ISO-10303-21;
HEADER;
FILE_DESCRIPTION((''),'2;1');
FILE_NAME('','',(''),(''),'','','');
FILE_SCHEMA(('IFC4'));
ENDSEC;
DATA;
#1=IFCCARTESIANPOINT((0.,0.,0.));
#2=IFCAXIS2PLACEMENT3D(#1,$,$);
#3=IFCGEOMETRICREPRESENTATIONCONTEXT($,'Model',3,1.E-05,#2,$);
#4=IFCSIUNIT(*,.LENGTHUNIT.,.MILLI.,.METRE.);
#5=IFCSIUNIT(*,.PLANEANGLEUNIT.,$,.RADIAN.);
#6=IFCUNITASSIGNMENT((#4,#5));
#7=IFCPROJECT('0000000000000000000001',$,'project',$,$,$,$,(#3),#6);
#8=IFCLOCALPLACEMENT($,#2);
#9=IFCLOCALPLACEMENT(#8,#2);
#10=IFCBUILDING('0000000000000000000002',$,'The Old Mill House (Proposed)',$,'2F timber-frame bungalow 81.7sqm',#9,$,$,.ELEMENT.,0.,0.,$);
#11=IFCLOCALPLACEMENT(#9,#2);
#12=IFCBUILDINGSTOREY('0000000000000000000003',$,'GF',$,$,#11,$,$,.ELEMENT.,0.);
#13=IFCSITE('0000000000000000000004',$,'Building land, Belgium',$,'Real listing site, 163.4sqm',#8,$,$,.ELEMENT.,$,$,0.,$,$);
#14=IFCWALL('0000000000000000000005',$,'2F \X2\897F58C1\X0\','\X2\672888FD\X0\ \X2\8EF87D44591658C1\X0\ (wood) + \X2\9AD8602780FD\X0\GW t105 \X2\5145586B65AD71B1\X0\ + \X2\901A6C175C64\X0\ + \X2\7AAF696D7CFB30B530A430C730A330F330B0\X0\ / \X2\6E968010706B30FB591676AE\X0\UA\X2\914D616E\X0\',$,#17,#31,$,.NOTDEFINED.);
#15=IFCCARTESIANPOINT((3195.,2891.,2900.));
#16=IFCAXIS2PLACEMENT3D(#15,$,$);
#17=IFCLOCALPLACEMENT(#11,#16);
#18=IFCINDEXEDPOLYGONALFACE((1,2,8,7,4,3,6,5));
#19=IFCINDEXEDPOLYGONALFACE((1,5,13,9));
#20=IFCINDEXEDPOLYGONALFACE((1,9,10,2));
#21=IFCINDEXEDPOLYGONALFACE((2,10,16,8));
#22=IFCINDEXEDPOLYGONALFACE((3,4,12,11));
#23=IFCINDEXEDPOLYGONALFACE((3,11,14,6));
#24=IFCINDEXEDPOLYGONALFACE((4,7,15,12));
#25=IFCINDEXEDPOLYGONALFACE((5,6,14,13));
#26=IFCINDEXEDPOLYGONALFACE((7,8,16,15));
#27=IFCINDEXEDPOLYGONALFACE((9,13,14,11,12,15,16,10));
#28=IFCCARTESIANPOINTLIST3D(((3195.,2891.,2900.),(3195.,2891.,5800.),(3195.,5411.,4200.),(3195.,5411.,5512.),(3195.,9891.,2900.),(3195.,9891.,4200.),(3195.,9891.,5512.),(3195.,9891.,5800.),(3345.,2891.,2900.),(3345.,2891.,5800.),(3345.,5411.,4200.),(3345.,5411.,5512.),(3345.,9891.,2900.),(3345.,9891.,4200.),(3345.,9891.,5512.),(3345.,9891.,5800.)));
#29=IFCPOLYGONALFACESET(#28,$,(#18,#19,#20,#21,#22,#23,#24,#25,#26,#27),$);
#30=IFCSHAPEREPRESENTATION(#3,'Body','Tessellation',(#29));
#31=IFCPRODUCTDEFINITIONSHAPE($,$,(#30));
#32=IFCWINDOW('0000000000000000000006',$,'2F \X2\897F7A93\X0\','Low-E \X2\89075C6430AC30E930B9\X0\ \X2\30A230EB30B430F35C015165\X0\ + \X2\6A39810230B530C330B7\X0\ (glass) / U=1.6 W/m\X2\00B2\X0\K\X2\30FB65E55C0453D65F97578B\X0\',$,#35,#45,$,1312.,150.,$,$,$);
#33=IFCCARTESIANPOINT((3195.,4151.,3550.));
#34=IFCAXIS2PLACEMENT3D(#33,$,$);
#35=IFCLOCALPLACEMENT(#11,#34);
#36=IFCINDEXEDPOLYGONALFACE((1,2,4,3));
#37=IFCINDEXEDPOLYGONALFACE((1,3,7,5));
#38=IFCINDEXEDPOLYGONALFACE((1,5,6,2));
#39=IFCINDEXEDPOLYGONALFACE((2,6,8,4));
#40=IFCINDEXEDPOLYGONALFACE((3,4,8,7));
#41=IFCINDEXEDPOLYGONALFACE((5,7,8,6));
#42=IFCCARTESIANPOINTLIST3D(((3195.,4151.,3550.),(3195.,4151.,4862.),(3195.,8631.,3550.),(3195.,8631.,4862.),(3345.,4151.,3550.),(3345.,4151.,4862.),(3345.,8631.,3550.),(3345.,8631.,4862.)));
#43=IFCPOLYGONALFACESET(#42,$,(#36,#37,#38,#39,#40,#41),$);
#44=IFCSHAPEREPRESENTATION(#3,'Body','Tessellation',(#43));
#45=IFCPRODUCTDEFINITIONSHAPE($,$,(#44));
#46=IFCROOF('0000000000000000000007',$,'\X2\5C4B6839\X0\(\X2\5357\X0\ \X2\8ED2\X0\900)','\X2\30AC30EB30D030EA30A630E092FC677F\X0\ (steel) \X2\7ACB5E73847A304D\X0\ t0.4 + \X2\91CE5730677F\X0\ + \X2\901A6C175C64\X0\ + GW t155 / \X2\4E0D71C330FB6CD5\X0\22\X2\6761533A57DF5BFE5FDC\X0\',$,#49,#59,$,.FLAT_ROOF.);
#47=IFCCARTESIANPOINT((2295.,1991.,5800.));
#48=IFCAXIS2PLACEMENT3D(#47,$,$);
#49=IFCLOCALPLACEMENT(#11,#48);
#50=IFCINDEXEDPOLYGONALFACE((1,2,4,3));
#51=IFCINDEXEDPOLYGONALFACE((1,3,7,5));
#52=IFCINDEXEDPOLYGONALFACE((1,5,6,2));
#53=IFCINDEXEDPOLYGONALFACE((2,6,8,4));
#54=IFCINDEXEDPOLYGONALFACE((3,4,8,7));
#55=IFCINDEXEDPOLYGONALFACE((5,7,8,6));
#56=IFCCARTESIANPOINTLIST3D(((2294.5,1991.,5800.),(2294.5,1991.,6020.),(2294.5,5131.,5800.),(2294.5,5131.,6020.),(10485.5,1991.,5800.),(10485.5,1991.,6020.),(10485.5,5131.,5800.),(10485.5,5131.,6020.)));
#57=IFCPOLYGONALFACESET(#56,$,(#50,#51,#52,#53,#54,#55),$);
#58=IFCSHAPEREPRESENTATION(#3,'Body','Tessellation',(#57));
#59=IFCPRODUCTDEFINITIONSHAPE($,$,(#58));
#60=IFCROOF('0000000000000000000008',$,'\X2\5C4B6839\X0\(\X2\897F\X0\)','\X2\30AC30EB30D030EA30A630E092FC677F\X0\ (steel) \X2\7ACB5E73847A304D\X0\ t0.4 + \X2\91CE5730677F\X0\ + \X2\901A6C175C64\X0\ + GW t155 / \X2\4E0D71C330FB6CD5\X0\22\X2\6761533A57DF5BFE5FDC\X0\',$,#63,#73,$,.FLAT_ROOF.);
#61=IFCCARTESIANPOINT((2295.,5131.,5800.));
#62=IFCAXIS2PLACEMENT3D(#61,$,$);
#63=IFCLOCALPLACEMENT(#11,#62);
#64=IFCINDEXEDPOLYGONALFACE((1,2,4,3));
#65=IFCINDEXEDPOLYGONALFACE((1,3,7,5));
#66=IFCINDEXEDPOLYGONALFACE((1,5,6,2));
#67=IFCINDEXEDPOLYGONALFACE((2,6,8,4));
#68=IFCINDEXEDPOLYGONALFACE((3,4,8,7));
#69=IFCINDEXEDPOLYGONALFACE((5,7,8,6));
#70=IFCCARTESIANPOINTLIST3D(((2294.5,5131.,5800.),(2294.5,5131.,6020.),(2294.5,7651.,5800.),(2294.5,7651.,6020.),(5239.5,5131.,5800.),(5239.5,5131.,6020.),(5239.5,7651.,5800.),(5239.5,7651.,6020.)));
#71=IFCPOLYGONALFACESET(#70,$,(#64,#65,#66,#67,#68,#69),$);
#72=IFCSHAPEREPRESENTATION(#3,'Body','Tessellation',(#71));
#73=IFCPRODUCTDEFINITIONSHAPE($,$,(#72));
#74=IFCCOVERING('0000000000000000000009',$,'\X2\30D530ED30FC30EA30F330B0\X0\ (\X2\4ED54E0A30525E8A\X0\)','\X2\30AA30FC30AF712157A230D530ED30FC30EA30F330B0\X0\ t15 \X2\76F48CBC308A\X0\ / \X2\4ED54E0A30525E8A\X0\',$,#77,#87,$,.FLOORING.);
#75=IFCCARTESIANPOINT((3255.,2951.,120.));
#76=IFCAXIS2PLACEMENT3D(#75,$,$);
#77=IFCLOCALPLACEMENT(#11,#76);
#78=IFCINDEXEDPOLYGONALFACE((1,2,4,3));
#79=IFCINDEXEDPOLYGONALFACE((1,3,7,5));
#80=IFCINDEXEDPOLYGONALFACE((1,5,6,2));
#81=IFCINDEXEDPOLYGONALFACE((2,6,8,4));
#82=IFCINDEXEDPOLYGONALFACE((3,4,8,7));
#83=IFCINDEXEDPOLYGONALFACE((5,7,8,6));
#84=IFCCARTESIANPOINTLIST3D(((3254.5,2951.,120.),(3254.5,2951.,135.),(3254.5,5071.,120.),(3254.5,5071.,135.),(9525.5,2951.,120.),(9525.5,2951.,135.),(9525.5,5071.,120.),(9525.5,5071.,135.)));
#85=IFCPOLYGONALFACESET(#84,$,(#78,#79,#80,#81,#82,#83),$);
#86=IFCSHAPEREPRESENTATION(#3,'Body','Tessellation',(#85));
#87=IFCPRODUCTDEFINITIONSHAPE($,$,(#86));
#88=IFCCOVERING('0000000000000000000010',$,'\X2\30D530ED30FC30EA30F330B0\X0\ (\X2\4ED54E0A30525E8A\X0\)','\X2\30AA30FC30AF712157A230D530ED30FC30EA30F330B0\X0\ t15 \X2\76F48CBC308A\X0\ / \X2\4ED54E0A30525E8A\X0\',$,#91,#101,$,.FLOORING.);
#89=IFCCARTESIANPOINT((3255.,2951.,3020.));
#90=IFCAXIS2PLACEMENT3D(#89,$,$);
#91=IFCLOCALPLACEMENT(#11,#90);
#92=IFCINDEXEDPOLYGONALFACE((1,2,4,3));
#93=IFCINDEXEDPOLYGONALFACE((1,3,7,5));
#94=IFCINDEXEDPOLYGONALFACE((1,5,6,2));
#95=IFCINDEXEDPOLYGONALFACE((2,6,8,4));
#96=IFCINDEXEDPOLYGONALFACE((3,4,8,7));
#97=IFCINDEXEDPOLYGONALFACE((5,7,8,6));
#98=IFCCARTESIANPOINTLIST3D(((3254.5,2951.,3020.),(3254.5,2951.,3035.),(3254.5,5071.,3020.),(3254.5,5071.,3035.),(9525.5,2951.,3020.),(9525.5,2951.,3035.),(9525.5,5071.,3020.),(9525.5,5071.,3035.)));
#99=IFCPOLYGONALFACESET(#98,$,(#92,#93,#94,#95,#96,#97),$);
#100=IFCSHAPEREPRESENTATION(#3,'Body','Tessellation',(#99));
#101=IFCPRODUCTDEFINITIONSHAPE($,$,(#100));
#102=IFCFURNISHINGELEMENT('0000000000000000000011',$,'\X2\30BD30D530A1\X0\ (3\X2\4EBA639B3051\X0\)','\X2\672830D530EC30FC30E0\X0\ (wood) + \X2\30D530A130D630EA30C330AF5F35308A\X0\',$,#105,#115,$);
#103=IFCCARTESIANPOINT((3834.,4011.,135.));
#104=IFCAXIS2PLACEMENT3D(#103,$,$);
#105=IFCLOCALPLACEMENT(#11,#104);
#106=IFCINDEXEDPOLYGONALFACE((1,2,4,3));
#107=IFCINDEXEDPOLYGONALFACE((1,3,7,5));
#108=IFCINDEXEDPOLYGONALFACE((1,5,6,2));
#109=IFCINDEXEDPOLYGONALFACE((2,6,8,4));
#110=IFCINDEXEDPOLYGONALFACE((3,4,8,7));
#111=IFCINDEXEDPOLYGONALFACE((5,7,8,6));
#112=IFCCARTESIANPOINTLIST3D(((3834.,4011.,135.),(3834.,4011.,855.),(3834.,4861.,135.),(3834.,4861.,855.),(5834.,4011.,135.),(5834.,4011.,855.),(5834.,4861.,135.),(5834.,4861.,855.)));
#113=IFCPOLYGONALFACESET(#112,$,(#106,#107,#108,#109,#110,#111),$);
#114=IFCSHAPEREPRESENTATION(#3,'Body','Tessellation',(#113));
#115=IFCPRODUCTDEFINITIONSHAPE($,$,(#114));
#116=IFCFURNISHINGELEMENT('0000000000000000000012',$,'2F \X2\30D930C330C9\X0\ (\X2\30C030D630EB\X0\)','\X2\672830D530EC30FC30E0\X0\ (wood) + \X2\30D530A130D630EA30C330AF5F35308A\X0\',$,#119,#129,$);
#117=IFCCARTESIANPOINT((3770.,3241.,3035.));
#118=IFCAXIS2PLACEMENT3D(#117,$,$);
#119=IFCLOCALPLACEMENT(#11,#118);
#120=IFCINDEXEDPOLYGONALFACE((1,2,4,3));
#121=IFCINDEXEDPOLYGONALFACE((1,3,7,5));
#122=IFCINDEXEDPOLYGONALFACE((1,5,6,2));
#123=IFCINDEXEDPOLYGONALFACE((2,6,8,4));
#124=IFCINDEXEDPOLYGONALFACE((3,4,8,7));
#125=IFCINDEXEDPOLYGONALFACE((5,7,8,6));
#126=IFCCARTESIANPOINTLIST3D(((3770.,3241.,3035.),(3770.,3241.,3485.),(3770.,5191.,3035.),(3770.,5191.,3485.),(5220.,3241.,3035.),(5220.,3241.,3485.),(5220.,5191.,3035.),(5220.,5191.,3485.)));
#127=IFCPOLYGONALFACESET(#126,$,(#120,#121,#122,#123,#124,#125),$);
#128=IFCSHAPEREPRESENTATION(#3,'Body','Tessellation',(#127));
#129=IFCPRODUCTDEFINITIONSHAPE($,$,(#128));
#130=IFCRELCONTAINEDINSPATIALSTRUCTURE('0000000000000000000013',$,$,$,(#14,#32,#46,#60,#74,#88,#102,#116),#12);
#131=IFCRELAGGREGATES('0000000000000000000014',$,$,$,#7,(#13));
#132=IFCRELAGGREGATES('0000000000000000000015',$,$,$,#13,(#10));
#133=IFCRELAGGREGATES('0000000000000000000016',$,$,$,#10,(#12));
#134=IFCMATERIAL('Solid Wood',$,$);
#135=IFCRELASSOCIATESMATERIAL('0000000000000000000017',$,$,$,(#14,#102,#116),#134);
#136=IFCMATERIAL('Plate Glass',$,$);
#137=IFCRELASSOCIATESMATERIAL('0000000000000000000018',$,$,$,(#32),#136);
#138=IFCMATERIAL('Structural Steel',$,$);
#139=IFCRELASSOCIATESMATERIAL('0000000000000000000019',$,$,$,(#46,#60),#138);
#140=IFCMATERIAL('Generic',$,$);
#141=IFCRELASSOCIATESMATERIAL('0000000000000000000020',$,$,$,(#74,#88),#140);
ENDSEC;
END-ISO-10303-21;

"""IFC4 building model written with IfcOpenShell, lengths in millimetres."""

from ifc_helpers import new_model, si_unit, frame, frame_2d, origin, place, context, project, spatial, rectangle, extrude, material, element, fill, save


model = new_model("IFC4")

# Units and contexts
model_context = context("Model", 3, precision=1e-05, world=origin())
ifc_project = project(units=[si_unit("LENGTHUNIT", "METRE", prefix="MILLI"), si_unit("PLANEANGLEUNIT", "RADIAN")], contexts=[model_context])

# Site, building, storey
site_placement = place(None, origin())
site = spatial("IfcSite", under=ifc_project, at=site_placement, Name="Building land, Belgium", ObjectType="Real listing site, 163.4sqm", CompositionType="ELEMENT", RefElevation=0.0)
building_placement = place(site_placement, origin())
building = spatial("IfcBuilding", under=site, at=building_placement, Name="The Old Mill House (Proposed)", ObjectType="2F timber-frame bungalow 81.7sqm", CompositionType="ELEMENT", ElevationOfRefHeight=0.0, ElevationOfTerrain=0.0)
storey_placement = place(building_placement, origin())
storey = spatial("IfcBuildingStorey", under=building, at=storey_placement, Name="GF", CompositionType="ELEMENT", Elevation=0.0)

# Shared definitions
ifc_material_1 = material(Name="Solid Wood")

# Shared definitions
ifc_material_2 = material(Name="Plate Glass")

# Wall, opening, window
wall_1_placement = place(storey_placement, frame((3195.0, 2891.0, 2900.0)))
wall_1 = element("IfcWall", 1, at=wall_1_placement, inside=storey, material=ifc_material_1, Name="2F 西壁", Description="木製 軸組外壁 (wood) + 高性能GW t105 充填断熱 + 通気層 + 窯業系サイディング / 準耐火・外皮UA配慮", PredefinedType="NOTDEFINED", context=model_context, shape_type="SweptSolid", body=[
    extrude(rectangle(XDim=150.0, YDim=7000.0, at=frame_2d((75.0, 3500.0))), frame((3195.0, 2891.0, 2900.0)), (0.0, 0.0, 1.0), 2900.0),
])
opening_1_placement = place(storey_placement, frame((3195.0, 4151.0, 3550.0)))
opening_1 = element("IfcOpeningElement", 2, at=opening_1_placement, cuts=wall_1, PredefinedType="NOTDEFINED", context=model_context, shape_type="SweptSolid", body=[
    extrude(rectangle(XDim=150.0, YDim=4480.0, at=frame_2d((75.0, 2240.0))), frame((3195.0, 4151.0, 3550.0)), (0.0, 0.0, 1.0), 1312.0),
])
window_1_placement = place(storey_placement, frame((3195.0, 4151.0, 3550.0)))
window_1 = element("IfcWindow", 3, at=window_1_placement, inside=storey, material=ifc_material_2, Name="2F 西窓", Description="Low-E 複層ガラス アルゴン封入 + 樹脂サッシ (glass) / U=1.6 W/m²K・日射取得型", OverallHeight=1312.0, OverallWidth=150.0, context=model_context, shape_type="SweptSolid", body=[
    extrude(rectangle(XDim=150.0, YDim=4480.0, at=frame_2d((75.0, 2240.0))), frame((3195.0, 4151.0, 3550.0)), (0.0, 0.0, 1.0), 1312.0),
])
fill(opening_1, window_1)

# Roofs
ifc_material_3 = material(Name="Structural Steel")
roof_1_placement = place(storey_placement, frame((2295.0, 1991.0, 5800.0)))
element("IfcRoof", 4, at=roof_1_placement, inside=storey, material=ifc_material_3, Name="屋根(南 軒900)", Description="ガルバリウム鋼板 (steel) 立平葺き t0.4 + 野地板 + 通気層 + GW t155 / 不燃・法22条区域対応", PredefinedType="FLAT_ROOF", context=model_context, shape_type="SweptSolid", body=[
    extrude(rectangle(XDim=8191.0, YDim=3140.0, at=frame_2d((4095.0, 1570.0))), frame((2295.0, 1991.0, 5800.0)), (0.0, 0.0, 1.0), 220.0),
])
roof_2_placement = place(storey_placement, frame((2295.0, 5131.0, 5800.0)))
element("IfcRoof", 5, at=roof_2_placement, inside=storey, material=ifc_material_3, Name="屋根(西)", Description="ガルバリウム鋼板 (steel) 立平葺き t0.4 + 野地板 + 通気層 + GW t155 / 不燃・法22条区域対応", PredefinedType="FLAT_ROOF", context=model_context, shape_type="SweptSolid", body=[
    extrude(rectangle(XDim=2945.0, YDim=2520.0, at=frame_2d((1472.0, 1260.0))), frame((2295.0, 5131.0, 5800.0)), (0.0, 0.0, 1.0), 220.0),
])

# Coverings
ifc_material_4 = material(Name="Generic")
covering_1_placement = place(storey_placement, frame((3255.0, 2951.0, 120.0)))
element("IfcCovering", 6, at=covering_1_placement, inside=storey, material=ifc_material_4, Name="フローリング (仕上げ床)", Description="オーク無垢フローリング t15 直貼り / 仕上げ床", PredefinedType="FLOORING", context=model_context, shape_type="SweptSolid", body=[
    extrude(rectangle(XDim=6271.0, YDim=2120.0, at=frame_2d((3135.0, 1060.0))), frame((3255.0, 2951.0, 120.0)), (0.0, 0.0, 1.0), 15.0),
])
covering_2_placement = place(storey_placement, frame((3255.0, 2951.0, 3020.0)))
element("IfcCovering", 7, at=covering_2_placement, inside=storey, material=ifc_material_4, Name="フローリング (仕上げ床)", Description="オーク無垢フローリング t15 直貼り / 仕上げ床", PredefinedType="FLOORING", context=model_context, shape_type="SweptSolid", body=[
    extrude(rectangle(XDim=6271.0, YDim=2120.0, at=frame_2d((3135.0, 1060.0))), frame((3255.0, 2951.0, 3020.0)), (0.0, 0.0, 1.0), 15.0),
])

# Furnishing elements
furnishing_1_placement = place(storey_placement, frame((3834.0, 4011.0, 135.0)))
element("IfcFurnishingElement", 8, at=furnishing_1_placement, inside=storey, material=ifc_material_1, Name="ソファ (3人掛け)", Description="木フレーム (wood) + ファブリック張り", context=model_context, shape_type="SweptSolid", body=[
    extrude(rectangle(XDim=2000.0, YDim=850.0, at=frame_2d((1000.0, 425.0))), frame((3834.0, 4011.0, 135.0)), (0.0, 0.0, 1.0), 720.0),
])
furnishing_2_placement = place(storey_placement, frame((3770.0, 3241.0, 3035.0)))
element("IfcFurnishingElement", 9, at=furnishing_2_placement, inside=storey, material=ifc_material_1, Name="2F ベッド (ダブル)", Description="木フレーム (wood) + ファブリック張り", context=model_context, shape_type="SweptSolid", body=[
    extrude(rectangle(XDim=1450.0, YDim=1950.0, at=frame_2d((725.0, 975.0))), frame((3770.0, 3241.0, 3035.0)), (0.0, 0.0, 1.0), 450.0),
])

save(model, "model.ifc")
